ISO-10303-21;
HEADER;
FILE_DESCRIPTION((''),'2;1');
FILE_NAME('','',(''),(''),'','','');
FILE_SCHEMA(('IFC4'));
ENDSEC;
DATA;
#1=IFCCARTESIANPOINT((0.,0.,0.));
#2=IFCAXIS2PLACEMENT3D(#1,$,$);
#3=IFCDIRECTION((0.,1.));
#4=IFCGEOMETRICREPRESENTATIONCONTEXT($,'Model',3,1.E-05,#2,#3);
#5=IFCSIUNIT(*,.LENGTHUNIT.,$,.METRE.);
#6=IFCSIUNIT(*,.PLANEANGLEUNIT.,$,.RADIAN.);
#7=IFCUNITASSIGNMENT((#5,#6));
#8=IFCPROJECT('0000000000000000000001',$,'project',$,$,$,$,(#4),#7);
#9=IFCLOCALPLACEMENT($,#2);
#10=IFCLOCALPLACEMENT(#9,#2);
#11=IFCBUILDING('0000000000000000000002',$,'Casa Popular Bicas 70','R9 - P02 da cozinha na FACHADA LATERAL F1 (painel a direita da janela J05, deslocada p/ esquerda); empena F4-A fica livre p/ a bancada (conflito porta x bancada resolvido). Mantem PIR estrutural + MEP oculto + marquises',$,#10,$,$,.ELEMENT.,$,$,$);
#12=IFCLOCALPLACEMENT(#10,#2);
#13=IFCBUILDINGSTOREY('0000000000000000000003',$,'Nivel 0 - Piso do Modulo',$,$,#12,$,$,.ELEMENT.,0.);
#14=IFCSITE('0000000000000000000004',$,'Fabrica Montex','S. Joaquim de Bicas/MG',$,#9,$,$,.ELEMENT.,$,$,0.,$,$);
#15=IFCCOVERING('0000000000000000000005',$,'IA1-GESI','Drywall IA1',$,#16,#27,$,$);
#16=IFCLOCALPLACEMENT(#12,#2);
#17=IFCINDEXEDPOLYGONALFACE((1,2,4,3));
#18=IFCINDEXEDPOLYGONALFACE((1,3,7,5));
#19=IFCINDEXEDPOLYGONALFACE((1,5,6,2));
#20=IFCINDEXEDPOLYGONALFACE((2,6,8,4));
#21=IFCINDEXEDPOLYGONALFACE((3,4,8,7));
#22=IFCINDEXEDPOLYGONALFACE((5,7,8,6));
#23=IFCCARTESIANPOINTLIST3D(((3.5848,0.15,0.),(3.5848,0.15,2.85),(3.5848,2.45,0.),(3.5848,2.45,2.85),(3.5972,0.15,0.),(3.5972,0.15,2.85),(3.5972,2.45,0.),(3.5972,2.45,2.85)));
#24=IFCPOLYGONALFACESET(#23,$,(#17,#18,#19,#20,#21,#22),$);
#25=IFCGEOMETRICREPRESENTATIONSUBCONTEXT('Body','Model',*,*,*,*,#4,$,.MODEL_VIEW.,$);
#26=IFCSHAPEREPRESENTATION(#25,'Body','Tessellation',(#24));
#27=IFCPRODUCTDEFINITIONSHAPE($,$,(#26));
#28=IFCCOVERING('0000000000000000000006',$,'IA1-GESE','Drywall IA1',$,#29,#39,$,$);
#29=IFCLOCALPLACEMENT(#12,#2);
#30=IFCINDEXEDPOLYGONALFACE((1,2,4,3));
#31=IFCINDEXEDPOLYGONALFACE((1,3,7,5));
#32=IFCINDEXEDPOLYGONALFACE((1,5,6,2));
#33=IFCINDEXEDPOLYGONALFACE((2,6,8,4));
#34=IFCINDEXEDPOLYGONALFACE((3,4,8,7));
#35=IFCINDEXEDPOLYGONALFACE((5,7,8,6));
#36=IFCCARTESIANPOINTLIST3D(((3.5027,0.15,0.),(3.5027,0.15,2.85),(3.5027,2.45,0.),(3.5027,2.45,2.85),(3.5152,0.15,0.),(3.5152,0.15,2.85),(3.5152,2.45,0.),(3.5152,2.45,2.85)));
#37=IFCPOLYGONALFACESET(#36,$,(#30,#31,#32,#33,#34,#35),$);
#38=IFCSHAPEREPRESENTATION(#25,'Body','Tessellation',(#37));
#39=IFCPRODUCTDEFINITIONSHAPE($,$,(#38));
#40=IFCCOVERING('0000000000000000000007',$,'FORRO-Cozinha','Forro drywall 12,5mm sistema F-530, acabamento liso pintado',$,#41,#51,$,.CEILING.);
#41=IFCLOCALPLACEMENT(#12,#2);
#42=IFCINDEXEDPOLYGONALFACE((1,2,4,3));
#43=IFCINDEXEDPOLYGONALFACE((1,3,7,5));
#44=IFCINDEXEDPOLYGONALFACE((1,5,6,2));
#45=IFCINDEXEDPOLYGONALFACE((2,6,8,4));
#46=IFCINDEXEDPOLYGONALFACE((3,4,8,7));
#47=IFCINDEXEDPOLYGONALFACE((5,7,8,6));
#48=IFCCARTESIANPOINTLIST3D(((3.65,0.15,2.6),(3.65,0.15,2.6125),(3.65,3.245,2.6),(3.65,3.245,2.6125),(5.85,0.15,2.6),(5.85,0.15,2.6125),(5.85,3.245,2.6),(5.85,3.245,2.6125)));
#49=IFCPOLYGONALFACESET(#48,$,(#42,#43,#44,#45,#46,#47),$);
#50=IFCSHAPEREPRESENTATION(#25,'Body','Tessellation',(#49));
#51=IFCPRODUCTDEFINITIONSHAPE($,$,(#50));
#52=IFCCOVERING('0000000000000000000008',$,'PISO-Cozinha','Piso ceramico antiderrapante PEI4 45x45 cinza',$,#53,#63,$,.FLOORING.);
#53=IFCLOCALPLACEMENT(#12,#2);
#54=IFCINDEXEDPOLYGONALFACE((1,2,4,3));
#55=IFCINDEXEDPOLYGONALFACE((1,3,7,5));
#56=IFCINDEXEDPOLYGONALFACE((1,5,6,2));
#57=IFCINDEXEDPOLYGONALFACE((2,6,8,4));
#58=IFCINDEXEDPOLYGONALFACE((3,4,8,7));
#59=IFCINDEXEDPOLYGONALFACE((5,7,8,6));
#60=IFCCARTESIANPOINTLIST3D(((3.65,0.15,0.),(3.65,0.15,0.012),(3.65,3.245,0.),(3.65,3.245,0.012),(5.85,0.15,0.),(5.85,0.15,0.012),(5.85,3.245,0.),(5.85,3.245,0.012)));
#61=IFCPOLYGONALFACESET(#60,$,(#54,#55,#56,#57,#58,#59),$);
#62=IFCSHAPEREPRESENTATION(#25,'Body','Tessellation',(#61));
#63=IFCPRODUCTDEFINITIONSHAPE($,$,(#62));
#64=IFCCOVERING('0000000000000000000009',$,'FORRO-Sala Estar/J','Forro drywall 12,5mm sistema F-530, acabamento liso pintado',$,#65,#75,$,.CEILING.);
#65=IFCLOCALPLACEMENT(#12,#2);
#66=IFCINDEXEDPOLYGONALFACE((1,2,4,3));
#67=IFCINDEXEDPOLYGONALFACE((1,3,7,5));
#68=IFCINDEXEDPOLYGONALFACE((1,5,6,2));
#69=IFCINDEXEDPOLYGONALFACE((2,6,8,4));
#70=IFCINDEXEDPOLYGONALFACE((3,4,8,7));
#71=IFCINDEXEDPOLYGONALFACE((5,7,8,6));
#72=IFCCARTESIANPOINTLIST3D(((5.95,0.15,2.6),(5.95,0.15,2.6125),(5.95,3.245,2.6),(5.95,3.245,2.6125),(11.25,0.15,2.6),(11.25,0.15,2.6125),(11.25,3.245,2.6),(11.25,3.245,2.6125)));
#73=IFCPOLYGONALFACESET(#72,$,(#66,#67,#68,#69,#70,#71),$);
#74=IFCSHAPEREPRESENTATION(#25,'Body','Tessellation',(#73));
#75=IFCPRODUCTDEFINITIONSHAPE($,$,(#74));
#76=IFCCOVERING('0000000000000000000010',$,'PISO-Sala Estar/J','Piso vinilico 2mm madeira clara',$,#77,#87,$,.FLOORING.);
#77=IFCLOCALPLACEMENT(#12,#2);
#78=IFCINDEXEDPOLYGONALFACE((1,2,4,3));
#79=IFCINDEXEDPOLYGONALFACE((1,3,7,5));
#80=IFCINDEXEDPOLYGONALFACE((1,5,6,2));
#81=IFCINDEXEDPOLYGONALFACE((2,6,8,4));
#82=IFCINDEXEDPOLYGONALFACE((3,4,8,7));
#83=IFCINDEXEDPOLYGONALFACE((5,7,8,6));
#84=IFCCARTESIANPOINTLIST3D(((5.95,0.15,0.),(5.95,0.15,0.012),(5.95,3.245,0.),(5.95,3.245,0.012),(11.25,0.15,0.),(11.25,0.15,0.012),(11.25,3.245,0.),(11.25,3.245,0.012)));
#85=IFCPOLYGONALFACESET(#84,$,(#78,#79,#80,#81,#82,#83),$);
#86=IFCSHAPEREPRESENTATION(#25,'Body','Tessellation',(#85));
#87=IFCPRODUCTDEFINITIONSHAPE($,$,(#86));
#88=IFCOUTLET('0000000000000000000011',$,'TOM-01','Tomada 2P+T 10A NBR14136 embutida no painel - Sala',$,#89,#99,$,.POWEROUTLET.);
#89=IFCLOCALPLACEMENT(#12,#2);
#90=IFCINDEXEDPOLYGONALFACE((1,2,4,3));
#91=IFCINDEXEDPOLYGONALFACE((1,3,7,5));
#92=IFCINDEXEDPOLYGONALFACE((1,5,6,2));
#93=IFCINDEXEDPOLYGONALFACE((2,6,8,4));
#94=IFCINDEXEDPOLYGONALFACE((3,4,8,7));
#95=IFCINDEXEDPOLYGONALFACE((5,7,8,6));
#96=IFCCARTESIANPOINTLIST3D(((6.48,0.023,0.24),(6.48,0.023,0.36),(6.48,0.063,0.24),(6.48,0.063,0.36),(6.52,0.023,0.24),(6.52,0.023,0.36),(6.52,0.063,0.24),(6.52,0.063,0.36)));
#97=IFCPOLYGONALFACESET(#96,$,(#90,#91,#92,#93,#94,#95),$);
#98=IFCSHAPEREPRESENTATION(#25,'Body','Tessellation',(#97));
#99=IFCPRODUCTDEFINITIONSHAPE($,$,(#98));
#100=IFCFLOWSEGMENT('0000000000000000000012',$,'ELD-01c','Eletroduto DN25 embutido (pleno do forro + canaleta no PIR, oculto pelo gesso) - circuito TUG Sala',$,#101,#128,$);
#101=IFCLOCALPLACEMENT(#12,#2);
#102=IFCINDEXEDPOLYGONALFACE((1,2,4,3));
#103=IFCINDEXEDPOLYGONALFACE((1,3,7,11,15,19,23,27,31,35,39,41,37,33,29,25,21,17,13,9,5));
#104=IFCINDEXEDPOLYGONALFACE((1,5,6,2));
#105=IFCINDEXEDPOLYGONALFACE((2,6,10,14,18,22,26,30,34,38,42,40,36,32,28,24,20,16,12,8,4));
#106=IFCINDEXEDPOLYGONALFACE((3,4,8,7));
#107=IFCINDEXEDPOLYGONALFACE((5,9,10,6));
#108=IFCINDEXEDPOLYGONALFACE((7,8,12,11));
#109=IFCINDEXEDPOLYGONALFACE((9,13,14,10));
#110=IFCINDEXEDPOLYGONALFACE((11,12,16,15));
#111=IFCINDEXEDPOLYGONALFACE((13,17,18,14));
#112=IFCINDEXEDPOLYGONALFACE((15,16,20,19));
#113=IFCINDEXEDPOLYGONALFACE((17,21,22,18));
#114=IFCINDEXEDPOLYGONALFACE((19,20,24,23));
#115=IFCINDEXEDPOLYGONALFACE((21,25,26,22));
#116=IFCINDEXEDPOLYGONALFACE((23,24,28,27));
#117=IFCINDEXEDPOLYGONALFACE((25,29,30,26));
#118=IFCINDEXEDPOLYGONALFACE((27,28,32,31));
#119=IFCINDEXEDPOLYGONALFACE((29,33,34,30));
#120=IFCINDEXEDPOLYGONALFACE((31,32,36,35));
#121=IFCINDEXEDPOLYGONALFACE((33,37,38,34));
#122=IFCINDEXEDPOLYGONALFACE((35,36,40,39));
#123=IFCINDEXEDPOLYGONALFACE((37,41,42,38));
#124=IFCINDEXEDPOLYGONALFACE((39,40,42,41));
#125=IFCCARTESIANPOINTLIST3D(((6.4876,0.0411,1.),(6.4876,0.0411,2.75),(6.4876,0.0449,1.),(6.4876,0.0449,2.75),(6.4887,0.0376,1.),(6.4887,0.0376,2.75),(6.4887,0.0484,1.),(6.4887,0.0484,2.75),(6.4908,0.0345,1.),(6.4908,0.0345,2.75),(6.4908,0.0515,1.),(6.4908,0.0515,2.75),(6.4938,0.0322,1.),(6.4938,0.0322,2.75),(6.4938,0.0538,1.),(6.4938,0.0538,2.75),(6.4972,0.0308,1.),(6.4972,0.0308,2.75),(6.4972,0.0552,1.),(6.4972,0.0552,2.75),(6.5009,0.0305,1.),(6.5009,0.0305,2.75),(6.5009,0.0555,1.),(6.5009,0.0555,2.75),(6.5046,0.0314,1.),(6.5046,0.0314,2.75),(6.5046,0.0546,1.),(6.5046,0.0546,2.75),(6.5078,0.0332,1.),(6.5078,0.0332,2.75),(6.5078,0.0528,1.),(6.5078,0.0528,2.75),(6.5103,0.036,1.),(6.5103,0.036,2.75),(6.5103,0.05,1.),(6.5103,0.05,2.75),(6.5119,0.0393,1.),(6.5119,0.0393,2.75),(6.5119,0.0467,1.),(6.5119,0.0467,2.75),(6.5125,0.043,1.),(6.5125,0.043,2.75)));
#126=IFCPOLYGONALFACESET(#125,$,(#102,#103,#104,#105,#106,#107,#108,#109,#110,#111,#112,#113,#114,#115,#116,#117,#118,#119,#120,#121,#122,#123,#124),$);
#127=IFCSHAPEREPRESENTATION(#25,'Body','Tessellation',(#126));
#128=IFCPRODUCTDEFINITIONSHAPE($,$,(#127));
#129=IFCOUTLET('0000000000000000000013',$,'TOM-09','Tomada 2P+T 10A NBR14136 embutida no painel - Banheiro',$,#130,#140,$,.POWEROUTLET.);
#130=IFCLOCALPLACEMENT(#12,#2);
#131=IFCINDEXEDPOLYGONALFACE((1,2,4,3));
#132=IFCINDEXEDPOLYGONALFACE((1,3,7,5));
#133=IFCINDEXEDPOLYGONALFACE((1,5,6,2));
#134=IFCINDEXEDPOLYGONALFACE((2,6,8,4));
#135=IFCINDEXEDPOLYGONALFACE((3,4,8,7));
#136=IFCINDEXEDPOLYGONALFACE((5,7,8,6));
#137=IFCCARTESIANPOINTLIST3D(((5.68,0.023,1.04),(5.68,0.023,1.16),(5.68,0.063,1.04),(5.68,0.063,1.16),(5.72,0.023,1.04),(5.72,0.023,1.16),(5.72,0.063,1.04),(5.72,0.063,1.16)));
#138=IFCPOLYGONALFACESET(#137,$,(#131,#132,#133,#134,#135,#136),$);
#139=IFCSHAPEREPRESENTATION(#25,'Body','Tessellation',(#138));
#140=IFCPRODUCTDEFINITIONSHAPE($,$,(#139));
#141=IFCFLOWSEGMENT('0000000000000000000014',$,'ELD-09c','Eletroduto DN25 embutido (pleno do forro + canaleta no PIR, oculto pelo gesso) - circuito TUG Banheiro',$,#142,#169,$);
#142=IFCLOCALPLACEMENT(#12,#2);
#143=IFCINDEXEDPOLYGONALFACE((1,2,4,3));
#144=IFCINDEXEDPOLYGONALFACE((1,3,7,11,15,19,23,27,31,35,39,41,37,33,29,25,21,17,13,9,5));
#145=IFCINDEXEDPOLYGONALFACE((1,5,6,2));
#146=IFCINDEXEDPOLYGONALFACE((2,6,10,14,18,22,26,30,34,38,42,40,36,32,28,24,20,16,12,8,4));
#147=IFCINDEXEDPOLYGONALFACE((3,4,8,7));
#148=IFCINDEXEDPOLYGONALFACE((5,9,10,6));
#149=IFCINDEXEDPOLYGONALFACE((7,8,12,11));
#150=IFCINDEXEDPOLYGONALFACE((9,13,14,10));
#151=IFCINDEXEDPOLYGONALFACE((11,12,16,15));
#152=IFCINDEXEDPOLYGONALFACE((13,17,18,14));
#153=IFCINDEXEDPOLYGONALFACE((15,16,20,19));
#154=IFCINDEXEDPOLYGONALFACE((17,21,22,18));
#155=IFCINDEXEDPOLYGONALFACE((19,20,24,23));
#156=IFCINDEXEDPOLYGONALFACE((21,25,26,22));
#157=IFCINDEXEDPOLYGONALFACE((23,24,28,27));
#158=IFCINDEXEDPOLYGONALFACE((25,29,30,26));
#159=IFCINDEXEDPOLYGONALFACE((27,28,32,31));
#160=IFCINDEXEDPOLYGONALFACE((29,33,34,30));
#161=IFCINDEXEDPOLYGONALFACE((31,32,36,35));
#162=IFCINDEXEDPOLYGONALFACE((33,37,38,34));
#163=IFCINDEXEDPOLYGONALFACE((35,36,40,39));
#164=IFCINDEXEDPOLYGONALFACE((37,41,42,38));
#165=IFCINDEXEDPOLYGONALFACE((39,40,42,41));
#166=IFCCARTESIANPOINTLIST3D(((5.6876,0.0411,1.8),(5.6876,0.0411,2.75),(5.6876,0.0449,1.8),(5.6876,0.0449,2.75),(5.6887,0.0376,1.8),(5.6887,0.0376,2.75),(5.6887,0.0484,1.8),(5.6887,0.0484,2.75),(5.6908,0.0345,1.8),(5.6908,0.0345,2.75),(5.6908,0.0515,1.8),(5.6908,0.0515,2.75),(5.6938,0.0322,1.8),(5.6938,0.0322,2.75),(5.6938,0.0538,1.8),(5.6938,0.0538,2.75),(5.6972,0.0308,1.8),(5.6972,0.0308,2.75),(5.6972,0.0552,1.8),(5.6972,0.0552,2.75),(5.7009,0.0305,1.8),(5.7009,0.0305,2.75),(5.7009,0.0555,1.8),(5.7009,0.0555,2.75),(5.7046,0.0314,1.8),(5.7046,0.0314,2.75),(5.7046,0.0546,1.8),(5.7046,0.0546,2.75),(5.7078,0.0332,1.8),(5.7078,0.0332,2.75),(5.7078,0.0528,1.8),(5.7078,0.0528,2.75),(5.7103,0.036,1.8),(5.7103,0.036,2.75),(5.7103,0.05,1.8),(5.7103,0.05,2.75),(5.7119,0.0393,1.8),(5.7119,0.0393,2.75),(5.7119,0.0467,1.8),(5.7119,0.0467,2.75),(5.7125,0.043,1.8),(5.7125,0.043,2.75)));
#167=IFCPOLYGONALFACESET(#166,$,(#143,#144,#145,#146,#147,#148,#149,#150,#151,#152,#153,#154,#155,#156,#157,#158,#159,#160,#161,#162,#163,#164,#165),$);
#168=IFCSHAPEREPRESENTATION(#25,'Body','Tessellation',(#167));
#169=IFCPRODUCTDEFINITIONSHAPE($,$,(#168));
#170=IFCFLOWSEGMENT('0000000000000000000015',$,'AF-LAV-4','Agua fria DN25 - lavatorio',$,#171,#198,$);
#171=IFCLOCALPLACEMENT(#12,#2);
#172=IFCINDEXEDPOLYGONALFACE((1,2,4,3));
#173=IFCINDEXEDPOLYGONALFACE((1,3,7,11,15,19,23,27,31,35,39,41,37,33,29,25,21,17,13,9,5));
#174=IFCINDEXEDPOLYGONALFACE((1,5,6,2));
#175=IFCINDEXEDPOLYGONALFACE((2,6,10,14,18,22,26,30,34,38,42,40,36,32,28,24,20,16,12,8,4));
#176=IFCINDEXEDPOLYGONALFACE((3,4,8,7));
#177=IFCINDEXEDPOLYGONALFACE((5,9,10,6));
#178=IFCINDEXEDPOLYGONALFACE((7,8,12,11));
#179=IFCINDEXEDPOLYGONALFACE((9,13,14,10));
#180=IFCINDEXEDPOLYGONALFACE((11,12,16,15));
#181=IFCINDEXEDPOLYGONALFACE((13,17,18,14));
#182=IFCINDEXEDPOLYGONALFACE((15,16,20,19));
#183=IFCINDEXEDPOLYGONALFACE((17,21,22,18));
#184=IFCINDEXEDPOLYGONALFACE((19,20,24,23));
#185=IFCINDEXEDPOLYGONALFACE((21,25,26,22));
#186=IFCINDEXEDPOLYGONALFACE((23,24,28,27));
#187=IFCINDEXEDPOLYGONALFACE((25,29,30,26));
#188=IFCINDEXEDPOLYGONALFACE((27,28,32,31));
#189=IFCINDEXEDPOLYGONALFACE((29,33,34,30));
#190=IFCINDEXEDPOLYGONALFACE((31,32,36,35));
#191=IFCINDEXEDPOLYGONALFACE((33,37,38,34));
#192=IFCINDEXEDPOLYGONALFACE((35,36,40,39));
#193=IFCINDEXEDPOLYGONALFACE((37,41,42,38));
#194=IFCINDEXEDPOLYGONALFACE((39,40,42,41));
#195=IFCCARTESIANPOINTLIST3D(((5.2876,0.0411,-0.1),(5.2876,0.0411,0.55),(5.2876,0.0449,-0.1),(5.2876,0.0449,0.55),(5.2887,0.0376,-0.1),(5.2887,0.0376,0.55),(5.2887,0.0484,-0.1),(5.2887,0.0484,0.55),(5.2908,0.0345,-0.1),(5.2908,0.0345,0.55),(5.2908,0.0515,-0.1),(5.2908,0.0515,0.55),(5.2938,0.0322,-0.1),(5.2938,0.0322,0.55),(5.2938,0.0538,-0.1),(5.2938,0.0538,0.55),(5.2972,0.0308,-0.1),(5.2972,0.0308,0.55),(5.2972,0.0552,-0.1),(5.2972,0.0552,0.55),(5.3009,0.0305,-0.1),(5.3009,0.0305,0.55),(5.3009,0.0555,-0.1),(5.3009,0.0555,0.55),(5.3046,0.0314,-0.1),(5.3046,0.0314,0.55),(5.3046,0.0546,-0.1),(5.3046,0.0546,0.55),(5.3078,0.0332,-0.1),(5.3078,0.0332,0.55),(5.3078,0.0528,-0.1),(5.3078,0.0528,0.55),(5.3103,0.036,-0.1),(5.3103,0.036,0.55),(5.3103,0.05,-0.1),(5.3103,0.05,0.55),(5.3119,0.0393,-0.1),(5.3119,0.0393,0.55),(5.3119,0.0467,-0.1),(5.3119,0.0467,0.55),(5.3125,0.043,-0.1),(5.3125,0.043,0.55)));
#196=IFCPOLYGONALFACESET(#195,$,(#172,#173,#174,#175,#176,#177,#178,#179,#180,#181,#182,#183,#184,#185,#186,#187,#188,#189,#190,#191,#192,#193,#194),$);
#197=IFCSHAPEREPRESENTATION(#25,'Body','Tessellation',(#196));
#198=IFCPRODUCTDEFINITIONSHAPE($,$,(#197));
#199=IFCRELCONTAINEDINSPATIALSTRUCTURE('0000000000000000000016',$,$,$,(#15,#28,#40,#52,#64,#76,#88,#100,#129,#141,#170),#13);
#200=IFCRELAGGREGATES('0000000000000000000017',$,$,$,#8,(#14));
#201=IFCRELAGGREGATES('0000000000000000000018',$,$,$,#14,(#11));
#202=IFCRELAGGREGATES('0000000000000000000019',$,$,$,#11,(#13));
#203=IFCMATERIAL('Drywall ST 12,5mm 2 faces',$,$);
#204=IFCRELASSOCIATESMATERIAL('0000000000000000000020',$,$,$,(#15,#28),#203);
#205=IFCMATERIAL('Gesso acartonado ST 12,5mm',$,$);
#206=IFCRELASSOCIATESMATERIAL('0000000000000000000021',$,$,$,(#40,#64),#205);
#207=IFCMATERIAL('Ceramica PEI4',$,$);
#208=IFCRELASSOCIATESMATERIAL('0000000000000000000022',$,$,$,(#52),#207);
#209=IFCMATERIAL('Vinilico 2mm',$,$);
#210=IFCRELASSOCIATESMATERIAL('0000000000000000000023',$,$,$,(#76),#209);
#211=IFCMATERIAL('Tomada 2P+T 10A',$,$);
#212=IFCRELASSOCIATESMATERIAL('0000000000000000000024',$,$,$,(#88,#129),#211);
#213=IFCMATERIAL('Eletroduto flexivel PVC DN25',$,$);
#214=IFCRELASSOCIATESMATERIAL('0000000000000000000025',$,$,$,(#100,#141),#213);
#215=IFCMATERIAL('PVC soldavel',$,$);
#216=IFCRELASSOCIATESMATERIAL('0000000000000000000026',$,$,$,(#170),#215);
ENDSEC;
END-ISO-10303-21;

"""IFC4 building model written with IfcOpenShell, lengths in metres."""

from ifc_helpers import new_model, si_unit, direction, frame, frame_2d, origin, origin_2d, place, context, subcontext, project, spatial, rectangle, circle, extrude, material, element, save


model = new_model("IFC4")

# Units and contexts
model_context = context("Model", 3, precision=1e-05, world=origin(), true_north=direction((0.0, 1.0)))
body_context = subcontext(model_context, "Body", "Model", "MODEL_VIEW")
ifc_project = project(units=[si_unit("LENGTHUNIT", "METRE"), si_unit("PLANEANGLEUNIT", "RADIAN")], contexts=[model_context])

# Site, building, storey
site_placement = place(None, origin())
site = spatial("IfcSite", under=ifc_project, at=site_placement, Name="Fabrica Montex", Description="S. Joaquim de Bicas/MG", CompositionType="ELEMENT", RefElevation=0.0)
building_placement = place(site_placement, origin())
building = spatial("IfcBuilding", under=site, at=building_placement, Name="Casa Popular Bicas 70", Description="R9 - P02 da cozinha na FACHADA LATERAL F1 (painel a direita da janela J05, deslocada p/ esquerda); empena F4-A fica livre p/ a bancada (conflito porta x bancada resolvido). Mantem PIR estrutural + MEP oculto + marquises", CompositionType="ELEMENT")
storey_placement = place(building_placement, origin())
storey = spatial("IfcBuildingStorey", under=building, at=storey_placement, Name="Nivel 0 - Piso do Modulo", CompositionType="ELEMENT", Elevation=0.0)

# Coverings
ifc_material_1 = material(Name="Drywall ST 12,5mm 2 faces")
for number, where, x_axis, name in (
    (1, (3.591, 0.15, 0.0), (0.0, 1.0, 0.0), "IA1-GESI"),
    (2, (3.509, 0.15, 0.0), (0.0, 1.0, 0.0), "IA1-GESE"),
):
    element("IfcCovering", number, at=place(storey_placement, frame(where, x_axis=x_axis)), inside=storey, material=ifc_material_1, Name=name, Description="Drywall IA1", context=body_context, shape_type="SweptSolid", body=[
        extrude(rectangle(XDim=2.3, YDim=0.0125, at=frame_2d((1.15, 0.0))), origin(), (0.0, 0.0, 1.0), 2.85),
    ])
ifc_material_2 = material(Name="Gesso acartonado ST 12,5mm")
covering_1_placement = place(storey_placement, frame((3.65, 0.15, 2.6)))
element("IfcCovering", 3, at=covering_1_placement, inside=storey, material=ifc_material_2, Name="FORRO-Cozinha", Description="Forro drywall 12,5mm sistema F-530, acabamento liso pintado", PredefinedType="CEILING", context=body_context, shape_type="SweptSolid", body=[
    extrude(rectangle(XDim=2.2, YDim=3.095, at=frame_2d((1.1, 1.5475))), origin(), (0.0, 0.0, 1.0), 0.0125),
])
ifc_material_3 = material(Name="Ceramica PEI4")
covering_2_placement = place(storey_placement, frame((3.65, 0.15, 0.0)))
element("IfcCovering", 4, at=covering_2_placement, inside=storey, material=ifc_material_3, Name="PISO-Cozinha", Description="Piso ceramico antiderrapante PEI4 45x45 cinza", PredefinedType="FLOORING", context=body_context, shape_type="SweptSolid", body=[
    extrude(rectangle(XDim=2.2, YDim=3.095, at=frame_2d((1.1, 1.5475))), origin(), (0.0, 0.0, 1.0), 0.012),
])
covering_3_placement = place(storey_placement, frame((5.95, 0.15, 2.6)))
element("IfcCovering", 5, at=covering_3_placement, inside=storey, material=ifc_material_2, Name="FORRO-Sala Estar/J", Description="Forro drywall 12,5mm sistema F-530, acabamento liso pintado", PredefinedType="CEILING", context=body_context, shape_type="SweptSolid", body=[
    extrude(rectangle(XDim=5.3, YDim=3.095, at=frame_2d((2.65, 1.5475))), origin(), (0.0, 0.0, 1.0), 0.0125),
])
ifc_material_4 = material(Name="Vinilico 2mm")
covering_4_placement = place(storey_placement, frame((5.95, 0.15, 0.0)))
element("IfcCovering", 6, at=covering_4_placement, inside=storey, material=ifc_material_4, Name="PISO-Sala Estar/J", Description="Piso vinilico 2mm madeira clara", PredefinedType="FLOORING", context=body_context, shape_type="SweptSolid", body=[
    extrude(rectangle(XDim=5.3, YDim=3.095, at=frame_2d((2.65, 1.5475))), origin(), (0.0, 0.0, 1.0), 0.012),
])

# Outlet
ifc_material_5 = material(Name="Tomada 2P+T 10A")
outlet_1_placement = place(storey_placement, frame((6.48, 0.023, 0.24)))
element("IfcOutlet", 7, at=outlet_1_placement, inside=storey, material=ifc_material_5, Name="TOM-01", Description="Tomada 2P+T 10A NBR14136 embutida no painel - Sala", PredefinedType="POWEROUTLET", context=body_context, shape_type="SweptSolid", body=[
    extrude(rectangle(XDim=0.04, YDim=0.04, at=frame_2d((0.02, 0.02))), origin(), (0.0, 0.0, 1.0), 0.12),
])

# Flow segment
ifc_material_6 = material(Name="Eletroduto flexivel PVC DN25")
flow_segment_1_placement = place(storey_placement, frame((6.5, 0.043, 2.75), z_axis=(0.0, 0.0, -1.0), x_axis=(1.0, 0.0, 0.0)))
element("IfcFlowSegment", 8, at=flow_segment_1_placement, inside=storey, material=ifc_material_6, Name="ELD-01c", Description="Eletroduto DN25 embutido (pleno do forro + canaleta no PIR, oculto pelo gesso) - circuito TUG Sala", context=body_context, shape_type="SweptSolid", body=[
    extrude(circle(Radius=0.0125, at=origin_2d()), origin(), (0.0, 0.0, 1.0), 1.75),
])

# Outlet
outlet_2_placement = place(storey_placement, frame((5.68, 0.023, 1.04)))
element("IfcOutlet", 9, at=outlet_2_placement, inside=storey, material=ifc_material_5, Name="TOM-09", Description="Tomada 2P+T 10A NBR14136 embutida no painel - Banheiro", PredefinedType="POWEROUTLET", context=body_context, shape_type="SweptSolid", body=[
    extrude(rectangle(XDim=0.04, YDim=0.04, at=frame_2d((0.02, 0.02))), origin(), (0.0, 0.0, 1.0), 0.12),
])

# Flow segments
flow_segment_2_placement = place(storey_placement, frame((5.7, 0.043, 2.75), z_axis=(0.0, 0.0, -1.0), x_axis=(1.0, 0.0, 0.0)))
element("IfcFlowSegment", 10, at=flow_segment_2_placement, inside=storey, material=ifc_material_6, Name="ELD-09c", Description="Eletroduto DN25 embutido (pleno do forro + canaleta no PIR, oculto pelo gesso) - circuito TUG Banheiro", context=body_context, shape_type="SweptSolid", body=[
    extrude(circle(Radius=0.0125, at=origin_2d()), origin(), (0.0, 0.0, 1.0), 0.95),
])
ifc_material_7 = material(Name="PVC soldavel")
flow_segment_3_placement = place(storey_placement, frame((5.3, 0.043, -0.1), z_axis=(0.0, 0.0, 1.0), x_axis=(1.0, 0.0, 0.0)))
element("IfcFlowSegment", 11, at=flow_segment_3_placement, inside=storey, material=ifc_material_7, Name="AF-LAV-4", Description="Agua fria DN25 - lavatorio", context=body_context, shape_type="SweptSolid", body=[
    extrude(circle(Radius=0.0125, at=origin_2d()), origin(), (0.0, 0.0, 1.0), 0.65),
])

save(model, "model.ifc")
